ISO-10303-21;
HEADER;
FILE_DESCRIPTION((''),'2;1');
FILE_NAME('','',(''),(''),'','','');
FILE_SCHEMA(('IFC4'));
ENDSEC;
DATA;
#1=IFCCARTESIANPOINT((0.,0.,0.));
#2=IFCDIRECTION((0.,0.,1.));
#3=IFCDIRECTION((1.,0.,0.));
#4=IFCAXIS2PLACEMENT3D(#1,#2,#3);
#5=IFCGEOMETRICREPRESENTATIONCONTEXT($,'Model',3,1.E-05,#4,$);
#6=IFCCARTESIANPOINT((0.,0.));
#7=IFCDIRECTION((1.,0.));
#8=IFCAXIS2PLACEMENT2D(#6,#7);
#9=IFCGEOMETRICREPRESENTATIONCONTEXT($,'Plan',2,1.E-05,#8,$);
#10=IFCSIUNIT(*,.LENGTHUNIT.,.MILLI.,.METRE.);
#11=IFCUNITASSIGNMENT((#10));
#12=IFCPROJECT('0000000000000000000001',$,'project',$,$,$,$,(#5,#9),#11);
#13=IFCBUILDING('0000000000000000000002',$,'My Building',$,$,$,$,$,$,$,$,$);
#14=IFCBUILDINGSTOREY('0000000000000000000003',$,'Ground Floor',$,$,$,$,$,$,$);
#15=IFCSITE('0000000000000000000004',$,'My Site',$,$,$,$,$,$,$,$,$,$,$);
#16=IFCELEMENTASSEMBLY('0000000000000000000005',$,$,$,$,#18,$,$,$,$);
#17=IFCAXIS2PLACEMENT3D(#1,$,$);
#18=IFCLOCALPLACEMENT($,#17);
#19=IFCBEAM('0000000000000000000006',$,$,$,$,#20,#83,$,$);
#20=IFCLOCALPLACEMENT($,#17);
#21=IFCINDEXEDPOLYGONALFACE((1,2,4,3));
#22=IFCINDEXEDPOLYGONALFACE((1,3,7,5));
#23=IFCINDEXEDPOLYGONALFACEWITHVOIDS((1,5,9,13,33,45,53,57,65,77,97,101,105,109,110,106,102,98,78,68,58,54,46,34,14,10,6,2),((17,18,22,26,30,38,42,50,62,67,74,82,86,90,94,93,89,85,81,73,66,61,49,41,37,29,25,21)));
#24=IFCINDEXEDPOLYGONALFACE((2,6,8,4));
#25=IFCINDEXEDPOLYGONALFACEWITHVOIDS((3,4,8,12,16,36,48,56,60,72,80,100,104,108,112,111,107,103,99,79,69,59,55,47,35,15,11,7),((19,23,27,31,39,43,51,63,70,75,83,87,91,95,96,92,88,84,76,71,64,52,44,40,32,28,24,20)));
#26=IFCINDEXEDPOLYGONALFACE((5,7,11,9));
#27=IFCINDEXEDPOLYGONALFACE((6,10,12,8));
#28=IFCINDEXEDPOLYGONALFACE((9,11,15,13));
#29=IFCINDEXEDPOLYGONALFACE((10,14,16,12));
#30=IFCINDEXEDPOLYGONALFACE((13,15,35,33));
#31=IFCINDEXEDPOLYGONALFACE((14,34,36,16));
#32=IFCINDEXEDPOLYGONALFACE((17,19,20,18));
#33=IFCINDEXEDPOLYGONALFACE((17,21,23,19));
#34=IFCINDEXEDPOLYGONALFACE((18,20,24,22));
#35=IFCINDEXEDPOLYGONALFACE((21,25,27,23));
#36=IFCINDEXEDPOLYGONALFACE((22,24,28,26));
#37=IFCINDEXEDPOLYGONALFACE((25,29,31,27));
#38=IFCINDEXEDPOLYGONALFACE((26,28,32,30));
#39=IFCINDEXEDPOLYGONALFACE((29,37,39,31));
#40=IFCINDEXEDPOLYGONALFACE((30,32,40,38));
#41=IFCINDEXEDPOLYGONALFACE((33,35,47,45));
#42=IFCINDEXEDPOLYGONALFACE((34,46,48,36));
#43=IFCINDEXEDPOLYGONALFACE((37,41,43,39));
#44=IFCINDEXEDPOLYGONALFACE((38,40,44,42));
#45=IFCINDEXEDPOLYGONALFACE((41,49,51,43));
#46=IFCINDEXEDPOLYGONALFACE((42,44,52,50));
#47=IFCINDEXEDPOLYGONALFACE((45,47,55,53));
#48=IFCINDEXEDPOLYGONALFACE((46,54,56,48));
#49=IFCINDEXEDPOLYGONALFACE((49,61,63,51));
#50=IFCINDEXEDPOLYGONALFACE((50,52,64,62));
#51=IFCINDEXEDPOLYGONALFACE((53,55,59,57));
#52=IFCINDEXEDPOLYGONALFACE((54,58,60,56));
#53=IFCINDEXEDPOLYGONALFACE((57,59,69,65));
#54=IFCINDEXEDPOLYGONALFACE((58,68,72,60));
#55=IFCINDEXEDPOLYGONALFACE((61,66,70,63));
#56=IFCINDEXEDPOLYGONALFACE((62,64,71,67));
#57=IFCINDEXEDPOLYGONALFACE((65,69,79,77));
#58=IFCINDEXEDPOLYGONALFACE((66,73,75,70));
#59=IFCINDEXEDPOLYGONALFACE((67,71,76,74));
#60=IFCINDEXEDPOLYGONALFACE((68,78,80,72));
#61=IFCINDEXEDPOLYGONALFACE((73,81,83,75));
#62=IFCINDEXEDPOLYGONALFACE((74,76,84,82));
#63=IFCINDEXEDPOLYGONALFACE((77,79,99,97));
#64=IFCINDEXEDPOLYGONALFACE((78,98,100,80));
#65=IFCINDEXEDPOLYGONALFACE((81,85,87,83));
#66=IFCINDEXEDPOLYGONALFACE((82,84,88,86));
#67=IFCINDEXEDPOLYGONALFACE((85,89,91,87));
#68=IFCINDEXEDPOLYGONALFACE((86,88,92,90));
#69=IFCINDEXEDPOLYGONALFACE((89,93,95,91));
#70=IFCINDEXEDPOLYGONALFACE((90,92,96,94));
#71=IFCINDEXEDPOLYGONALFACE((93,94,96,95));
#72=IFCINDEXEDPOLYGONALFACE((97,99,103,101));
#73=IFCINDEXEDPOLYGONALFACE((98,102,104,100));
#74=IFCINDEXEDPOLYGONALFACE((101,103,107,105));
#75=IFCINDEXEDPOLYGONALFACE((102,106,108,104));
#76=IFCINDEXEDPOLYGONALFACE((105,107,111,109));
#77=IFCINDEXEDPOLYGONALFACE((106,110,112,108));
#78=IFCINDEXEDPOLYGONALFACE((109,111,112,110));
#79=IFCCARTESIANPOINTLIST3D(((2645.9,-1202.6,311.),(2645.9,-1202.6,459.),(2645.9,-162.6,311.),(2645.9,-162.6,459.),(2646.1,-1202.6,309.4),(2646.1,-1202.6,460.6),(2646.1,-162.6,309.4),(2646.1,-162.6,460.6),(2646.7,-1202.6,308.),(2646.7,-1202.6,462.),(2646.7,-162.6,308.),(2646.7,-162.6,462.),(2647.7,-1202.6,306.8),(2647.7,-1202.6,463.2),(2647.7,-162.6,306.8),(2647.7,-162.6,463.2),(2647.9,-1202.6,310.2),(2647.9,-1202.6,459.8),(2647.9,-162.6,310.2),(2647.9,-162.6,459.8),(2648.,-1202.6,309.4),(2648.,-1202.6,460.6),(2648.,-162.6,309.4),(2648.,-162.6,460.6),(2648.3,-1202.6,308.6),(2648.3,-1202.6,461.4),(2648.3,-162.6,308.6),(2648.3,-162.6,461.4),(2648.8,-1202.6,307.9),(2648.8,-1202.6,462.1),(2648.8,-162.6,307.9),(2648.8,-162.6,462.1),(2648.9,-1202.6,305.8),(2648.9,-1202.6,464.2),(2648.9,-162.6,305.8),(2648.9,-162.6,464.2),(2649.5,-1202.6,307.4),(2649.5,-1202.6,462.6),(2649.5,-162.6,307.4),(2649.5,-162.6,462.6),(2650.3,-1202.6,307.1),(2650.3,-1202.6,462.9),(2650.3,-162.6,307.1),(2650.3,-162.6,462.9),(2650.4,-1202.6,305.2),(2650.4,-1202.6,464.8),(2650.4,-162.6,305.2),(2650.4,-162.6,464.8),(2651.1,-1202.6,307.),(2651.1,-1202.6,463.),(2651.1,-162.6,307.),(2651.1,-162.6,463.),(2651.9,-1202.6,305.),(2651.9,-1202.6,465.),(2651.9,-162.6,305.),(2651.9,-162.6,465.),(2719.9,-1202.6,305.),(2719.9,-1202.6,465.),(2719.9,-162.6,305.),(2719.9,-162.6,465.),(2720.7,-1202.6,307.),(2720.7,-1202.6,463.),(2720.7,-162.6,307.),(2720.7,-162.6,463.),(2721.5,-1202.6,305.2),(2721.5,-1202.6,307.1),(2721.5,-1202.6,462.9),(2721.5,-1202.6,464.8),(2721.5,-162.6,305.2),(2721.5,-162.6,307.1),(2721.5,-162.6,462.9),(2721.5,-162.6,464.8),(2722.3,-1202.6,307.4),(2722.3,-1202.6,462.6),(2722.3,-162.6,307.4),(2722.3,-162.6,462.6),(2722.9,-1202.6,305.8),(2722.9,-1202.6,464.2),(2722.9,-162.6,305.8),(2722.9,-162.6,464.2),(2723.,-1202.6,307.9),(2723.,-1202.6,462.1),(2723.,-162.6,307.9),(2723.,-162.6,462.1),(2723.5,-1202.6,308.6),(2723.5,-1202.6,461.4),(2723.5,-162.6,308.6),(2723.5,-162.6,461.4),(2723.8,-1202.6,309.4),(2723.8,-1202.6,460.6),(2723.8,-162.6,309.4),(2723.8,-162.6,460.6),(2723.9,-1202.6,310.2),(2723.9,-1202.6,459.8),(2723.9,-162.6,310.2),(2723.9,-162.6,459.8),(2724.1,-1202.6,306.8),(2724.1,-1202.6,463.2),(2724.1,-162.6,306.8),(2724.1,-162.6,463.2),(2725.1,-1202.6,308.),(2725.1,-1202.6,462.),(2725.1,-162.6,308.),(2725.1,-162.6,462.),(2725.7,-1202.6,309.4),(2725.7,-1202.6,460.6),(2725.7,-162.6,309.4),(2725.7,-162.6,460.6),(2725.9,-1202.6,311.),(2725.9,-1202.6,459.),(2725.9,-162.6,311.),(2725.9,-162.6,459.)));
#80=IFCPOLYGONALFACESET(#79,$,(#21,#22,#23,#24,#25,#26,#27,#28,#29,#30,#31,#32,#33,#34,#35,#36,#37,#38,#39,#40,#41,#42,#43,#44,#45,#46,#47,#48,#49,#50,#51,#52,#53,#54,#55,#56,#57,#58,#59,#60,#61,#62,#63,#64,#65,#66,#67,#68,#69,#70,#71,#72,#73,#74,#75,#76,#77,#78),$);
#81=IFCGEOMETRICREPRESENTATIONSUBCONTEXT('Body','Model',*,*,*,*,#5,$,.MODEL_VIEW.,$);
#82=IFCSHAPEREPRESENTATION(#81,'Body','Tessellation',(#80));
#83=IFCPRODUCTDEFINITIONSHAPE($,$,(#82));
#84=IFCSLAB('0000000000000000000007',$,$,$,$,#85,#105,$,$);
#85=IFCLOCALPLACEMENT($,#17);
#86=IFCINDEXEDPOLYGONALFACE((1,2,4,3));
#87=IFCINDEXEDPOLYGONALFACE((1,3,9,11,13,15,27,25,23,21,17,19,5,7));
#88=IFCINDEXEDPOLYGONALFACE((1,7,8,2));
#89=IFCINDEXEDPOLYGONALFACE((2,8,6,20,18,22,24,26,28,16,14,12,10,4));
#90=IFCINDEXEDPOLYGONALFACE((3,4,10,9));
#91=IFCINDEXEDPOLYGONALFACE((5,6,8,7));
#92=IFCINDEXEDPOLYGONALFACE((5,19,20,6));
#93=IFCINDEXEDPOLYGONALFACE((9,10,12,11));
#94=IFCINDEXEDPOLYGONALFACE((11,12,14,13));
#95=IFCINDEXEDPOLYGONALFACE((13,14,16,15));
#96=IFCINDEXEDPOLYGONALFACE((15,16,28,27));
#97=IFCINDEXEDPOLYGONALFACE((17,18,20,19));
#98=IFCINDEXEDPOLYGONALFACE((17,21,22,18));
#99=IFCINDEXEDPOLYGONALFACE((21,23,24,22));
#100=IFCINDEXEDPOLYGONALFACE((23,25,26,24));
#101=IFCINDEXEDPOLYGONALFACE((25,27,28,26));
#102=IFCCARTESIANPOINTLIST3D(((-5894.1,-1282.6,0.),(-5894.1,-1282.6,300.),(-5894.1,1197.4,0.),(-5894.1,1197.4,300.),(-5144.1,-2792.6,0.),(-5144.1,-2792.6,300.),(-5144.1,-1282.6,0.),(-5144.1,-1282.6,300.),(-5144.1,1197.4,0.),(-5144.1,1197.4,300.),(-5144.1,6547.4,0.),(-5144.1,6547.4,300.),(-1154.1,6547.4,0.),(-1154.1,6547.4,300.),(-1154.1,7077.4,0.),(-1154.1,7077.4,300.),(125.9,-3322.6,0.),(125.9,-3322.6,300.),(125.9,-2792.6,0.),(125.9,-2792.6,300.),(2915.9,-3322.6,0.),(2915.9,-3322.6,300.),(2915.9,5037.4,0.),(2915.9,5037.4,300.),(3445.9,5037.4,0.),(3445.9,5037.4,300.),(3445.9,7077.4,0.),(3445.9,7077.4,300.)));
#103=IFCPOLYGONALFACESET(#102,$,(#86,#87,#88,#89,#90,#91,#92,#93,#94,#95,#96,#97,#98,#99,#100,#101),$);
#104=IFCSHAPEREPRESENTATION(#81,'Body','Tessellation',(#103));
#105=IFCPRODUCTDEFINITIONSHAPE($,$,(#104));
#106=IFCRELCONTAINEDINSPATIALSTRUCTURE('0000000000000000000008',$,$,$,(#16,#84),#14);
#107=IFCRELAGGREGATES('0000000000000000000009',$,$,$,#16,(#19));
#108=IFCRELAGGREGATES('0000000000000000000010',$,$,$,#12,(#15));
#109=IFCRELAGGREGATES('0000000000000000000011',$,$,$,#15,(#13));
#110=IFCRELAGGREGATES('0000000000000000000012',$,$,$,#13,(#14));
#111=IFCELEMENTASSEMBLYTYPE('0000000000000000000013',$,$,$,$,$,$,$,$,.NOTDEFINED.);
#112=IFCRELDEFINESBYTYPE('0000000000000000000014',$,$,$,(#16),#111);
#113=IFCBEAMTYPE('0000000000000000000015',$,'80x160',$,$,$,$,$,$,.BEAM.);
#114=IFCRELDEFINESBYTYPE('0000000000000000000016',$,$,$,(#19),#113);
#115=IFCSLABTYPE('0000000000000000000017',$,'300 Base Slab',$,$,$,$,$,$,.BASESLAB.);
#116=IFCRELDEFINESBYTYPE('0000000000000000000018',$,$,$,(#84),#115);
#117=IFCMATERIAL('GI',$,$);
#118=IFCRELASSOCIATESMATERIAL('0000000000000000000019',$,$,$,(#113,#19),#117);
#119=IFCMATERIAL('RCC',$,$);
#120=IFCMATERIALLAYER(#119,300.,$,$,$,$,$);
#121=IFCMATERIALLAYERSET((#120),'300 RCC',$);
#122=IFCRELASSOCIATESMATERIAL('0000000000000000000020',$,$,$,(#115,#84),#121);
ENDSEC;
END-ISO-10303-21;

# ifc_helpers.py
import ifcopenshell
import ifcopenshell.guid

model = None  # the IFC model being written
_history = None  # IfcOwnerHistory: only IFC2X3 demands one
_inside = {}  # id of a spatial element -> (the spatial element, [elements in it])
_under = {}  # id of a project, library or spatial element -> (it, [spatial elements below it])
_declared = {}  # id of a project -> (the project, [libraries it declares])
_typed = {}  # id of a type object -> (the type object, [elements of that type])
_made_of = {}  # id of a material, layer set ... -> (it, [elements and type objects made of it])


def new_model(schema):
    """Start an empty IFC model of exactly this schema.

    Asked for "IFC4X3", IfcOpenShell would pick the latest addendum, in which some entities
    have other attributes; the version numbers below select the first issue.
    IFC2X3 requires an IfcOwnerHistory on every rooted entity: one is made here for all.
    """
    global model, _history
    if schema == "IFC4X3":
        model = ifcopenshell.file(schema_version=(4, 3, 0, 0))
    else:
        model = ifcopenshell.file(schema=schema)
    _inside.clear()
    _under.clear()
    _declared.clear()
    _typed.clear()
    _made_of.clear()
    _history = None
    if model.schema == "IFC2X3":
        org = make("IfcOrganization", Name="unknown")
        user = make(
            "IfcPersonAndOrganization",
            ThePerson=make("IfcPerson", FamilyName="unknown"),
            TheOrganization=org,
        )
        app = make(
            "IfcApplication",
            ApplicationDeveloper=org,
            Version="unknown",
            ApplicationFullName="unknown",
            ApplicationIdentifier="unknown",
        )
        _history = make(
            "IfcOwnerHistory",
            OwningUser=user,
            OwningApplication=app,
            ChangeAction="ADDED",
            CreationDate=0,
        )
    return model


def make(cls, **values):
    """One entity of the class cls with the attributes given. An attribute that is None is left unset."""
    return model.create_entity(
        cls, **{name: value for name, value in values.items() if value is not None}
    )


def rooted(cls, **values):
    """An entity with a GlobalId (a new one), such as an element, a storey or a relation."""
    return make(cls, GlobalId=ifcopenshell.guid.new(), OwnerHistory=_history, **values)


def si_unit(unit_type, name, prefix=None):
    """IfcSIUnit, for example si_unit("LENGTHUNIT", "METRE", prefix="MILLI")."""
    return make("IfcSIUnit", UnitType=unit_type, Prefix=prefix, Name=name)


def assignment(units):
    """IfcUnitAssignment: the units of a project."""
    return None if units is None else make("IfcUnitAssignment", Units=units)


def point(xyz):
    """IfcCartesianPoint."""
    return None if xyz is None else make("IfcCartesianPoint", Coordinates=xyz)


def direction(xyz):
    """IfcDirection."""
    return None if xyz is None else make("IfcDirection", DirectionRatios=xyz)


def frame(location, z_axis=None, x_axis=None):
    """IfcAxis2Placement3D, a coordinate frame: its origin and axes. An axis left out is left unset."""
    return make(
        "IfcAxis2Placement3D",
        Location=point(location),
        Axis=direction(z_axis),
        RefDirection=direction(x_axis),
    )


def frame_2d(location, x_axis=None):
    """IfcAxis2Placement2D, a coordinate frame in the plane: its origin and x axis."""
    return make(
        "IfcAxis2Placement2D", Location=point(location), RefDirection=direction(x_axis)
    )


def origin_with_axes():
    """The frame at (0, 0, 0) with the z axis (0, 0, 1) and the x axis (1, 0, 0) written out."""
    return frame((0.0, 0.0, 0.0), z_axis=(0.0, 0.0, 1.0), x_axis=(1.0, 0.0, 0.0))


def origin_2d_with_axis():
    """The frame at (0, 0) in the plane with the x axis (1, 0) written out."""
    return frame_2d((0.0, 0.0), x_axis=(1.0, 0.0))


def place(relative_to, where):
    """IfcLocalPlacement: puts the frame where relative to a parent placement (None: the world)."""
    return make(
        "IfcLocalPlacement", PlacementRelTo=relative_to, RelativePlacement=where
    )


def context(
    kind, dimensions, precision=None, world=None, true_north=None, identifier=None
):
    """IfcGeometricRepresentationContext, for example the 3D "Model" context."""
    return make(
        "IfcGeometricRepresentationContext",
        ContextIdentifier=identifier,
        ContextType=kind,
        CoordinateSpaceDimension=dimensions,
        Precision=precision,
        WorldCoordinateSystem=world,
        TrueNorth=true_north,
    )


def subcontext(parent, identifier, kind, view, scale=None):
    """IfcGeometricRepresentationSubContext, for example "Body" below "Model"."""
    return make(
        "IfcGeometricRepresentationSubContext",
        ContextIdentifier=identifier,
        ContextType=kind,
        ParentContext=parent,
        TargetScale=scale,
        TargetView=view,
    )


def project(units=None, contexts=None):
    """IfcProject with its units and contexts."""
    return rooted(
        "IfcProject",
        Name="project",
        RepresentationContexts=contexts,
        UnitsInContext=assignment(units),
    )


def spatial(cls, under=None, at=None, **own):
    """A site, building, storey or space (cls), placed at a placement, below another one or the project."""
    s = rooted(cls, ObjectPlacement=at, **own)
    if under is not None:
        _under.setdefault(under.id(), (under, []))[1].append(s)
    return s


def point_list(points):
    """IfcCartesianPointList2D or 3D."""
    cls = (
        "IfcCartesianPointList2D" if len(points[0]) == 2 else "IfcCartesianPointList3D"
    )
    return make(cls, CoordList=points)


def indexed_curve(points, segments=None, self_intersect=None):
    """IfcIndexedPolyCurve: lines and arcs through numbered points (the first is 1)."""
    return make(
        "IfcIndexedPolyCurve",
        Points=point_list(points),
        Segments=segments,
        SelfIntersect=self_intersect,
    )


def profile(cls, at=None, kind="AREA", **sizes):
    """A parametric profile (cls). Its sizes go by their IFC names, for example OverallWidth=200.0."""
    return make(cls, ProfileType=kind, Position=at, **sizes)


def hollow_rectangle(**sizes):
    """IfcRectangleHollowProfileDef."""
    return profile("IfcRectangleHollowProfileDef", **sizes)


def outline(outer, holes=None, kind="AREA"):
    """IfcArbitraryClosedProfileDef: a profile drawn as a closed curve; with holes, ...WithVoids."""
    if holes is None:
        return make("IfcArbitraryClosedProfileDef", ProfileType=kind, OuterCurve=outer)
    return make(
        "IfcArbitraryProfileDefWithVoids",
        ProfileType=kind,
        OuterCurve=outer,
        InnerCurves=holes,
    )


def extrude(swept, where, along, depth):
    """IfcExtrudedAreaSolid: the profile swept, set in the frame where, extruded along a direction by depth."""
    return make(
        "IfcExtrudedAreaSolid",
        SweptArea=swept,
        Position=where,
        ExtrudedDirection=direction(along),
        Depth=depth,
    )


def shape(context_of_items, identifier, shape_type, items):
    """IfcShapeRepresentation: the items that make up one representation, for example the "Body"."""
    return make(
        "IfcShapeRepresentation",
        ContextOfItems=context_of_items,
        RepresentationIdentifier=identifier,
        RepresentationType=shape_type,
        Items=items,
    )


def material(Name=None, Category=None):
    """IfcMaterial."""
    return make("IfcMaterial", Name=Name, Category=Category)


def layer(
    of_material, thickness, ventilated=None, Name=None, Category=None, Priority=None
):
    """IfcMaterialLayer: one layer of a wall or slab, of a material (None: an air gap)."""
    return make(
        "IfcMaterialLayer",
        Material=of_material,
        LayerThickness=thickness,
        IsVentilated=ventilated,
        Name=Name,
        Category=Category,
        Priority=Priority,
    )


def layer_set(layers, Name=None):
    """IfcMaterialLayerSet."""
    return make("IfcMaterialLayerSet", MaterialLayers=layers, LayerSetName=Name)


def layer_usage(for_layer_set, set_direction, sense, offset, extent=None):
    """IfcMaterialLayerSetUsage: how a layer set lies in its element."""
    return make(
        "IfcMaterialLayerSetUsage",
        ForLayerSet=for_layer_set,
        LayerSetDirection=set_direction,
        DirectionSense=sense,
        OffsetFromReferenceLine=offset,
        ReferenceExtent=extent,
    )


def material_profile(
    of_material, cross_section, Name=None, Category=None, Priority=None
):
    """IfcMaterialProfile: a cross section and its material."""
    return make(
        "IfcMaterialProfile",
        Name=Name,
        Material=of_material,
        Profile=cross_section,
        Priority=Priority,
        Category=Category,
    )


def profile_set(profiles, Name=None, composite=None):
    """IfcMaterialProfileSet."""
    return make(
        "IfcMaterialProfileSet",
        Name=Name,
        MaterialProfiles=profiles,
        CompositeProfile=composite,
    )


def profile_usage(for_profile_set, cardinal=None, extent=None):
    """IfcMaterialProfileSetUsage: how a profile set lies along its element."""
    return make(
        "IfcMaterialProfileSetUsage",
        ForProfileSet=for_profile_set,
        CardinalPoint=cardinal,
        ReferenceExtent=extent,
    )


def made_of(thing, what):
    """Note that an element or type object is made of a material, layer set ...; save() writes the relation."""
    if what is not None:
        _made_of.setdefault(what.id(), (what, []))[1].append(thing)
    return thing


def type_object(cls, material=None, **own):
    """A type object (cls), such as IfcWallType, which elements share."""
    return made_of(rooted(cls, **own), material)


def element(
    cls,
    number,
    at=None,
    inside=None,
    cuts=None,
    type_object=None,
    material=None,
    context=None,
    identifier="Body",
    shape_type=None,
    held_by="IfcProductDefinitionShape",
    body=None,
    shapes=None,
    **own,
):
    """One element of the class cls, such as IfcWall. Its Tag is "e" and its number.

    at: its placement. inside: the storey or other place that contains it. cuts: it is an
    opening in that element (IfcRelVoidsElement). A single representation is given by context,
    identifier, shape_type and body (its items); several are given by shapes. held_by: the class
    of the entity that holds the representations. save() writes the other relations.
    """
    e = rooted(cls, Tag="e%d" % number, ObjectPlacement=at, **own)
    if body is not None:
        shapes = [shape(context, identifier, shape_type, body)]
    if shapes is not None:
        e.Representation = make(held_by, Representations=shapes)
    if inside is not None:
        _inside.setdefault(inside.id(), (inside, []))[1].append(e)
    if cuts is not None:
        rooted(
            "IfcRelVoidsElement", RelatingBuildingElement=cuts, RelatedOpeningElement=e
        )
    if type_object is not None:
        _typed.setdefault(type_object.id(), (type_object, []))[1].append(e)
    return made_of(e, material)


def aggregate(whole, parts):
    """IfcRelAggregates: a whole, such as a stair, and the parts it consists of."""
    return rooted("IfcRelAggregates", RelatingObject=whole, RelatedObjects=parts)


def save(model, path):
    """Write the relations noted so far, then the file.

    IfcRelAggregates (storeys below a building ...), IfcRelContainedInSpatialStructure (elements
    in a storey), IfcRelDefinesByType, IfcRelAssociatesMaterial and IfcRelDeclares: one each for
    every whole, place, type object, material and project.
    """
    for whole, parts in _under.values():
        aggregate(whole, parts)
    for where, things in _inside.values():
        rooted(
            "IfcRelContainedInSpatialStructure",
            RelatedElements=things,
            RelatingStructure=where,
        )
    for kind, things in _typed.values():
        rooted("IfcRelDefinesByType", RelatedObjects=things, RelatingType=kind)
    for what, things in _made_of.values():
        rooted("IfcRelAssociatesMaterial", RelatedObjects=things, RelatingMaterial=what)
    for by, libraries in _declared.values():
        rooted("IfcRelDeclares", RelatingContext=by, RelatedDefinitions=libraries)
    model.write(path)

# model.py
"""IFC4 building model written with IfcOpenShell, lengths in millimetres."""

from ifc_helpers import new_model, si_unit, frame, origin_with_axes, origin_2d_with_axis, place, context, subcontext, project, spatial, indexed_curve, hollow_rectangle, outline, extrude, material, layer, layer_set, layer_usage, material_profile, profile_set, profile_usage, type_object, element, aggregate, save


model = new_model("IFC4")

# Units and contexts
model_context = context("Model", 3, precision=1e-05, world=origin_with_axes())
plan_context = context("Plan", 2, precision=1e-05, world=origin_2d_with_axis())
body_context = subcontext(model_context, "Body", "Model", "MODEL_VIEW")
ifc_project = project(units=[si_unit("LENGTHUNIT", "METRE", prefix="MILLI")], contexts=[model_context, plan_context])

# Site, building, storey
site = spatial("IfcSite", under=ifc_project, Name="My Site")
building = spatial("IfcBuilding", under=site, Name="My Building")
storey = spatial("IfcBuildingStorey", under=building, Name="Ground Floor")

# Shared definitions
ifc_material_1 = material(Name="GI")

# Element assembly, beam
element_assembly_type_1 = type_object("IfcElementAssemblyType", PredefinedType="NOTDEFINED")
ifc_material_profile_1 = material_profile(ifc_material_1, hollow_rectangle(XDim=80.0, YDim=160.0, WallThickness=2.0, InnerFilletRadius=3.2, OuterFilletRadius=6.0))
ifc_profile_set_1 = profile_set([ifc_material_profile_1], Name="80x160 GI Rectangular Hollow")
beam_type = type_object("IfcBeamType", Name="80x160", PredefinedType="BEAM", material=ifc_profile_set_1)
assembly_1_placement = place(None, frame((2685.9, -1282.6, 385.0), z_axis=(0.0, 1.0, 0.0), x_axis=(1.0, 0.0, 0.0)))
assembly_1 = element("IfcElementAssembly", 1, at=assembly_1_placement, inside=storey, type_object=element_assembly_type_1)
ifc_profile_usage_1 = profile_usage(ifc_profile_set_1)
beam_1_placement = place(assembly_1_placement, frame((0.0, 0.0, 80.0), z_axis=(0.0, 0.0, 1.0), x_axis=(1.0, 0.0, 0.0)))
beam_1 = element("IfcBeam", 2, at=beam_1_placement, type_object=beam_type, material=ifc_profile_usage_1, context=body_context, shape_type="SweptSolid", body=[
    extrude(hollow_rectangle(XDim=80.0, YDim=160.0, WallThickness=2.0, InnerFilletRadius=3.2, OuterFilletRadius=6.0), origin_with_axes(), (0.0, 0.0, 1.0), 1040.0),
])
aggregate(assembly_1, [beam_1])

# Slab
ifc_material_2 = material(Name="RCC")
ifc_layer = layer(ifc_material_2, 300.0)
ifc_layer_set = layer_set([ifc_layer], Name="300 RCC")
ifc_layer_usage = layer_usage(ifc_layer_set, "AXIS3", "POSITIVE", 0.0)
slab_type = type_object("IfcSlabType", Name="300 Base Slab", PredefinedType="BASESLAB", material=ifc_layer_set)
slab_placement = place(None, origin_with_axes())
element("IfcSlab", 3, at=slab_placement, inside=storey, type_object=slab_type, material=ifc_layer_usage, context=body_context, shape_type="SweptSolid", body=[
    extrude(outline(indexed_curve([(125.9, -3322.6), (2915.9, -3322.6), (2915.9, 5037.4), (3445.9, 5037.4), (3445.9, 7077.4), (-1154.1, 7077.4), (-1154.1, 6547.4), (-5144.1, 6547.4), (-5144.1, 1197.4), (-5894.1, 1197.4), (-5894.1, -1282.6), (-5144.1, -1282.6), (-5144.1, -2792.6), (125.9, -2792.6), (125.9, -3322.6)])), None, (0.0, 0.0, 1.0), 300.0),
])

save(model, "model.ifc")
